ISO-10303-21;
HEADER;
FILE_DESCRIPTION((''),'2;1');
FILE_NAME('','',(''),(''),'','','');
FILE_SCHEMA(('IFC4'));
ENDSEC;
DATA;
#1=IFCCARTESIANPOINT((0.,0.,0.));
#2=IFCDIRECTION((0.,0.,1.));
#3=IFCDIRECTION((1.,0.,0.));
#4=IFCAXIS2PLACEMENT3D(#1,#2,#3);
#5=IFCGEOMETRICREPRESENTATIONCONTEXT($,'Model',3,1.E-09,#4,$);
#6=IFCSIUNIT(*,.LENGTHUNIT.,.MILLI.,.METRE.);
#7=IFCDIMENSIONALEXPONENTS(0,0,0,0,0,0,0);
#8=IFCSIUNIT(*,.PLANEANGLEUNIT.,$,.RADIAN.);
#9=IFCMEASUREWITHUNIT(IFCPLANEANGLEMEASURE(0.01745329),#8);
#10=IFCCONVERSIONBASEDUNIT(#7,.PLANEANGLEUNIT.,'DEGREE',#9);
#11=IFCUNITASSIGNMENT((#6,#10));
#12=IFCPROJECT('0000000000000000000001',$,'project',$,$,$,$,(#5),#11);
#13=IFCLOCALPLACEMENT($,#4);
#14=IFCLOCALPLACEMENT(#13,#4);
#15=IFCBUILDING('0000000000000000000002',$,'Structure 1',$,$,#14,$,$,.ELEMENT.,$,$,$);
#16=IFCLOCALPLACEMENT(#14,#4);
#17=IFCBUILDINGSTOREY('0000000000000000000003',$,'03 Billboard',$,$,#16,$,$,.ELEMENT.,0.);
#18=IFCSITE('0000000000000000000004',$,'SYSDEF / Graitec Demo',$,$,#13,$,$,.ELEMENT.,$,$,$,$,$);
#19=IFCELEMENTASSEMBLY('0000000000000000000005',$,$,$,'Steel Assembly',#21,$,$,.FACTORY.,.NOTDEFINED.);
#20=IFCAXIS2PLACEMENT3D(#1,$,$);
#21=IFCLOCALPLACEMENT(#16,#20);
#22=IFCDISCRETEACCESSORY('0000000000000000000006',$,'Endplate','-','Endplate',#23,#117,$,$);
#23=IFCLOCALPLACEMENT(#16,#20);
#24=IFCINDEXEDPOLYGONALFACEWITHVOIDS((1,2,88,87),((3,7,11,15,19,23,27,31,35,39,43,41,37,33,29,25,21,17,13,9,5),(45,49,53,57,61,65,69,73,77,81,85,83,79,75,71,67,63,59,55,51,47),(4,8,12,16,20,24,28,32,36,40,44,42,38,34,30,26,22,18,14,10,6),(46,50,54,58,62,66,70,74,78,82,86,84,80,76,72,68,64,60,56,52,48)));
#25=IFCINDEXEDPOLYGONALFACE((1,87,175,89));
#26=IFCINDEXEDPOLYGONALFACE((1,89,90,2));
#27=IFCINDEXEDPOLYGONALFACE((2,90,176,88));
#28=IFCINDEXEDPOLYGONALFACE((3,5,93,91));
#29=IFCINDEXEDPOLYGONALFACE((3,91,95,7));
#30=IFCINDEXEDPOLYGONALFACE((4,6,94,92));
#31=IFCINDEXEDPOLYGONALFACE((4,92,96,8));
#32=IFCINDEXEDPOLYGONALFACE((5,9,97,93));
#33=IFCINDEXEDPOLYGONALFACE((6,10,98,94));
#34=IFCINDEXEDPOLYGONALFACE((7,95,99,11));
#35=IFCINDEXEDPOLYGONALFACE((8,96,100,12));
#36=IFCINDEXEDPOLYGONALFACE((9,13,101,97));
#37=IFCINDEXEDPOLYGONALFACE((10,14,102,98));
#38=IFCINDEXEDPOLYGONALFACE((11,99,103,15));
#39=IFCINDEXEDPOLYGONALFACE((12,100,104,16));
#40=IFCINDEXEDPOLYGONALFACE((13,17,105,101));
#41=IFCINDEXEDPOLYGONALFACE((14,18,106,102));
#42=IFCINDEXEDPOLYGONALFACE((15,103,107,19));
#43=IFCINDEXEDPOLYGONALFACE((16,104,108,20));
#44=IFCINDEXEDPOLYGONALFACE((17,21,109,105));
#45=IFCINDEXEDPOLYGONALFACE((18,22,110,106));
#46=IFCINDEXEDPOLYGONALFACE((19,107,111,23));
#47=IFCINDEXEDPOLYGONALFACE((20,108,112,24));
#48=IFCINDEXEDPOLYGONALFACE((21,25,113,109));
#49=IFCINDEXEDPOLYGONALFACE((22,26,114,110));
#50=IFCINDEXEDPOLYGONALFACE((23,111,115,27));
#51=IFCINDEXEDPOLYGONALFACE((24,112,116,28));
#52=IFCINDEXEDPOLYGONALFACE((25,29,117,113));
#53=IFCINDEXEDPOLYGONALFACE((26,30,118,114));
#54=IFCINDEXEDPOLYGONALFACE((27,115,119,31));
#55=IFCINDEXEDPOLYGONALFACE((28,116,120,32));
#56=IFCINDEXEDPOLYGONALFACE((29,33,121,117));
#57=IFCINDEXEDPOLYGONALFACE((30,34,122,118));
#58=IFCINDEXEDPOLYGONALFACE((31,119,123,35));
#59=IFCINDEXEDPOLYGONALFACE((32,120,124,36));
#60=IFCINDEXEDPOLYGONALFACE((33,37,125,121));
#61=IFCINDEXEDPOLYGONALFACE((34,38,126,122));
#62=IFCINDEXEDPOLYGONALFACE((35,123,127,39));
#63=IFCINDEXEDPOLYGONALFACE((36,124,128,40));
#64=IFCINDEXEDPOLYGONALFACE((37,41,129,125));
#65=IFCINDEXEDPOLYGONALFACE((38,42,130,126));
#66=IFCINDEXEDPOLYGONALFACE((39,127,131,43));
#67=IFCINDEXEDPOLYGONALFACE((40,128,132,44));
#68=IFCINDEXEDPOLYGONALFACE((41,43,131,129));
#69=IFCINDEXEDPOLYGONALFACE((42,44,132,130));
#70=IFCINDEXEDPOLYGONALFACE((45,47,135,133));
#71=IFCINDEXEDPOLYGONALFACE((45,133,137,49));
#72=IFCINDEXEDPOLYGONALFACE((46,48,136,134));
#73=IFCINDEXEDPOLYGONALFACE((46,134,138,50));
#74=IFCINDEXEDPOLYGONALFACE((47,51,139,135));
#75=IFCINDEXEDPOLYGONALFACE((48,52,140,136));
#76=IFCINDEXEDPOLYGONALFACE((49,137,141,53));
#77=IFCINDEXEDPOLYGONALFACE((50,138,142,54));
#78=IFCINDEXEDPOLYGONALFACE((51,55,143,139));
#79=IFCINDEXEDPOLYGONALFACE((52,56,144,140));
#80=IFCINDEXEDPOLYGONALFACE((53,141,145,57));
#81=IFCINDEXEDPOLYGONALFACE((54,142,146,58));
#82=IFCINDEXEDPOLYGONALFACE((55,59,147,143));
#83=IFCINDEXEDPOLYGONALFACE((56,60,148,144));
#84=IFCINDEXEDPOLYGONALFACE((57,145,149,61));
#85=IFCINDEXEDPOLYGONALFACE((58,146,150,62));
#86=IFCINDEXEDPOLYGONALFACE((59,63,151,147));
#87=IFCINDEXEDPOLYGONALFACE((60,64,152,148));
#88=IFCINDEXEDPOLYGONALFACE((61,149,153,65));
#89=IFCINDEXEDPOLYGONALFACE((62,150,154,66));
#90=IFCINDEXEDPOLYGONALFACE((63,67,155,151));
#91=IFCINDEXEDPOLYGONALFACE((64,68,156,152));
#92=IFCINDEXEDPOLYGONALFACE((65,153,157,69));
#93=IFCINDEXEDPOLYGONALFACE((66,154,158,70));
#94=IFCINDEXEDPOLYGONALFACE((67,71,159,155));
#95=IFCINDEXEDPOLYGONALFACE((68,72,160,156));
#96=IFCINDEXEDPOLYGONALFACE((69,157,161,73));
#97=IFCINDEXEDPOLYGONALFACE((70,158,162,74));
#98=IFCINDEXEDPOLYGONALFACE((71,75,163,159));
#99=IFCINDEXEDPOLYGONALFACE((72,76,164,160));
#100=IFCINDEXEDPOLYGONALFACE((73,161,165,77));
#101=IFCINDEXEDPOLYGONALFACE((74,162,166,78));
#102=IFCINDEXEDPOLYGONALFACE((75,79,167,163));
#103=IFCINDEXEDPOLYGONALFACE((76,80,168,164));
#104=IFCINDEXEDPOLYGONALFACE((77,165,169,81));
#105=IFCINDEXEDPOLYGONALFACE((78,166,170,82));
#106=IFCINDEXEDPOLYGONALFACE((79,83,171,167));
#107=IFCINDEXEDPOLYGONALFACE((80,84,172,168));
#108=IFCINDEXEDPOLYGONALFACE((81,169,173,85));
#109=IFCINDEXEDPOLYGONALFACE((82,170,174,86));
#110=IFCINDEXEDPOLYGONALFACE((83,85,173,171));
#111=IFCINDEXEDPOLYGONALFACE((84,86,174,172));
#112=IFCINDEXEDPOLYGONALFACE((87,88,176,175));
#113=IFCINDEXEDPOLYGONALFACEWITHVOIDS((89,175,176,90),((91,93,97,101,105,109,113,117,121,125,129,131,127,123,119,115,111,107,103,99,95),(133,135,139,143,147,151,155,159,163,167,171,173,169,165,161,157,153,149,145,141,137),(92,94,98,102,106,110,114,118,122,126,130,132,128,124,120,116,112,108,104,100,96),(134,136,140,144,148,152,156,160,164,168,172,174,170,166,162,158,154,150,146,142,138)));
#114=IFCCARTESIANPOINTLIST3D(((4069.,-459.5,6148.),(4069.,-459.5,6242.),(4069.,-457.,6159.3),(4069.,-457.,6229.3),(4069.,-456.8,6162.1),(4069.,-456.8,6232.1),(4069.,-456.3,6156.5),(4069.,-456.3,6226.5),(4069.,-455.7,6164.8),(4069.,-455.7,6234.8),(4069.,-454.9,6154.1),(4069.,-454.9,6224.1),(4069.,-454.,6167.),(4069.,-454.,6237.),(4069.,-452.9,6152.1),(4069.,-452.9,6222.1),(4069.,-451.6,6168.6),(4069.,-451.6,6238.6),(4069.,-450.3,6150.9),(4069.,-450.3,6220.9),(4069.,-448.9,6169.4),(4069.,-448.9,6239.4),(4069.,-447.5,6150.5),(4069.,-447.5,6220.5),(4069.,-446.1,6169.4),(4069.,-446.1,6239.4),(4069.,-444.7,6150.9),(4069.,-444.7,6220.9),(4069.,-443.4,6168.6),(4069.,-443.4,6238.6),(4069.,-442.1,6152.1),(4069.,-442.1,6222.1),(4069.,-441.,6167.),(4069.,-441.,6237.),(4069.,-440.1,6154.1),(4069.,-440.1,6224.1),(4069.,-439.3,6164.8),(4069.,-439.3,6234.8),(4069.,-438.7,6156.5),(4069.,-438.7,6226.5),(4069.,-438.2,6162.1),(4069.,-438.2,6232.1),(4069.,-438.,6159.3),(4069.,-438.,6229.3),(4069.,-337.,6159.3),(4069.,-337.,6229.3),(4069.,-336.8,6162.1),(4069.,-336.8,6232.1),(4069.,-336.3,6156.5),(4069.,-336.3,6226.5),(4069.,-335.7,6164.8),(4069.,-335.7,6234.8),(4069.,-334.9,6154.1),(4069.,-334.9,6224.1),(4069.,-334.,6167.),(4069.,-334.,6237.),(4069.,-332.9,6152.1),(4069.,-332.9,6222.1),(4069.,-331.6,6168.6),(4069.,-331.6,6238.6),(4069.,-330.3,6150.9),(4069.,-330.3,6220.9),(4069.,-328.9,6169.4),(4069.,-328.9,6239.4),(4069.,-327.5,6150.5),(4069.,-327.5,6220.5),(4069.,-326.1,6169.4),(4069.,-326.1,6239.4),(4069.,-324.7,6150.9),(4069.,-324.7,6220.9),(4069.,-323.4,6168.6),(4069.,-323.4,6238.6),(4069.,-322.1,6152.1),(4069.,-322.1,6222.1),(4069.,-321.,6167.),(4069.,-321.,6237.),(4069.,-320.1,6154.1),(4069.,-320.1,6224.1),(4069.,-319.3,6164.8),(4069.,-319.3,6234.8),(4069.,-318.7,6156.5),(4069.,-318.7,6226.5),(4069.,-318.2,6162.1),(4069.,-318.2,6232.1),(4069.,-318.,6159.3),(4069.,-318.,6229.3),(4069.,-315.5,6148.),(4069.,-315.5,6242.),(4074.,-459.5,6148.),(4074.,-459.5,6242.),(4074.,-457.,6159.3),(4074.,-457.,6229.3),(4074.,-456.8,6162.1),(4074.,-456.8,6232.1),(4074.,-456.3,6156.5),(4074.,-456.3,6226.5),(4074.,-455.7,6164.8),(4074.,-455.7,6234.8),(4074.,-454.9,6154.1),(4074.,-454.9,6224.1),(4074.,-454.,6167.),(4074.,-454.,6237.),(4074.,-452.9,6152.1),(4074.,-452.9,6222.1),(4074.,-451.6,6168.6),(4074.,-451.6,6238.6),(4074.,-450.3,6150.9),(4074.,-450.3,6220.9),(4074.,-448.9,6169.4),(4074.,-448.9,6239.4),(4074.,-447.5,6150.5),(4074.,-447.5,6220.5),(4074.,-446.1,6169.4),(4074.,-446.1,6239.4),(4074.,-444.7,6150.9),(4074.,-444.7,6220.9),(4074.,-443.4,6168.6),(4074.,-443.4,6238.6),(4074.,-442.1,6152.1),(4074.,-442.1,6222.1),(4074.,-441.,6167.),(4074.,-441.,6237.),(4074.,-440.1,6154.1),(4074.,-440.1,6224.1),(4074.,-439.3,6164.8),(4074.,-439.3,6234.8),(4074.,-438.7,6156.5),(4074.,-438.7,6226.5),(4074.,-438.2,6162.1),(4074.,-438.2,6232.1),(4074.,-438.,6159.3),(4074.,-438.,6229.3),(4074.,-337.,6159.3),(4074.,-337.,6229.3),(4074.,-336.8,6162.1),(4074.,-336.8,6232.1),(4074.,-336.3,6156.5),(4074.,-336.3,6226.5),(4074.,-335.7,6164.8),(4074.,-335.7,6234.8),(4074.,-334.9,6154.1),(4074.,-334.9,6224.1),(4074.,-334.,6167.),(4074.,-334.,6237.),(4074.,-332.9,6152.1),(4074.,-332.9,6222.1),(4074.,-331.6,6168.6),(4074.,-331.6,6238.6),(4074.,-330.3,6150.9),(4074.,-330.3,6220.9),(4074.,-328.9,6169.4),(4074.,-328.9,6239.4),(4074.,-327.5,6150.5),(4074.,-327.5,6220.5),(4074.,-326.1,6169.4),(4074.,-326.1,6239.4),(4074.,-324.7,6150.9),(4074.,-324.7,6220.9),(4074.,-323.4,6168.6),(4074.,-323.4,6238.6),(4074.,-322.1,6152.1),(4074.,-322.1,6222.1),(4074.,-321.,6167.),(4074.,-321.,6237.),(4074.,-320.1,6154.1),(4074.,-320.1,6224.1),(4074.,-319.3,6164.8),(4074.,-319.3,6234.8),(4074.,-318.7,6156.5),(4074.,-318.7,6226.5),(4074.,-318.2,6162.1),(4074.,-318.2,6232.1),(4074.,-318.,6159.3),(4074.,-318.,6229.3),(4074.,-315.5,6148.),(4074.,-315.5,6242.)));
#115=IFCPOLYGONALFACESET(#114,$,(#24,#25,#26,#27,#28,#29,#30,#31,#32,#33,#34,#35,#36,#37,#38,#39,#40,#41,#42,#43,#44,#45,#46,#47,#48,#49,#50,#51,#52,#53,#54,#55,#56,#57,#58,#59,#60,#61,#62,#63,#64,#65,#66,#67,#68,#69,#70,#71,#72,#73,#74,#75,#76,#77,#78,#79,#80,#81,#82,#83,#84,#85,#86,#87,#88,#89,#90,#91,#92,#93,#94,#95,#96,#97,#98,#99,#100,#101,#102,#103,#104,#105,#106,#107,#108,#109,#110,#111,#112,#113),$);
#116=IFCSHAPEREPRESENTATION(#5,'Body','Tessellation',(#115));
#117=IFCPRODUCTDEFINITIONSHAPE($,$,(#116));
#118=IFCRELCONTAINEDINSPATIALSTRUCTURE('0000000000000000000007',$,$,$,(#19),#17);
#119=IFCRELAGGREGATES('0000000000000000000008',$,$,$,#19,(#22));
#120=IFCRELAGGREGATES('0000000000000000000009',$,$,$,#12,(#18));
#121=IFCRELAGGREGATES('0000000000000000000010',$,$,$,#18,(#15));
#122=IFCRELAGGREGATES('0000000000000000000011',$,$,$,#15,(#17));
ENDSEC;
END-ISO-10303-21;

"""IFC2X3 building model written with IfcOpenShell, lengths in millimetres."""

from ifc_helpers import new_model, entity, si_unit, converted_unit, frame, frame_2d, origin, origin_with_axes, place, context, project, spatial, polyline, circle, outline, extrude, element, aggregate, save


model = new_model("IFC2X3")

# Units and contexts
model_context = context("Model", 3, precision=1e-09, world=origin_with_axes())
ifc_project = project(units=[si_unit("LENGTHUNIT", "METRE", prefix="MILLI"), converted_unit("PLANEANGLEUNIT", "DEGREE", entity("IfcPlaneAngleMeasure", 0.01745329), si_unit("PLANEANGLEUNIT", "RADIAN"), dimensions=[0, 0, 0, 0, 0, 0, 0])], contexts=[model_context])

# Site, building, storey
site_placement = place(None, origin_with_axes())
site = spatial("IfcSite", under=ifc_project, at=site_placement, Name="SYSDEF / Graitec Demo", CompositionType="ELEMENT")
building_placement = place(site_placement, origin_with_axes())
building = spatial("IfcBuilding", under=site, at=building_placement, Name="Structure 1", CompositionType="ELEMENT")
storey_placement = place(building_placement, origin_with_axes())
storey = spatial("IfcBuildingStorey", under=building, at=storey_placement, Name="03 Billboard", CompositionType="ELEMENT", Elevation=0.0)

# Element assembly, discrete accessory, openings
assembly_1_placement = place(None, frame((-4239.1, -387.5, 4000.0), z_axis=(-1.0, 0.0, 0.0), x_axis=(0.0, 0.0, 1.0)))
assembly_1 = element("IfcElementAssembly", 1, at=assembly_1_placement, inside=storey, ObjectType="Steel Assembly", AssemblyPlace="FACTORY", PredefinedType="NOTDEFINED")
discrete_accessory_1_placement = place(assembly_1_placement, frame((2148.0, 72.0, -8308.1), z_axis=(0.0, 0.0, -1.0), x_axis=(1.0, 0.0, 0.0)))
discrete_accessory_1 = element("IfcDiscreteAccessory", 2, at=discrete_accessory_1_placement, Name="Endplate", Description="-", ObjectType="Endplate", context=model_context, shape_type="SweptSolid", body=[
    extrude(outline(polyline([(0.0, 0.0), (94.0, 0.0), (94.0, 144.0), (0.0, 144.0), (0.0, 0.0)])), origin_with_axes(), (0.0, 0.0, 1.0), 5.0),
])
opening_1_placement = place(discrete_accessory_1_placement, frame((47.0, 72.0, -0.5), z_axis=(0.0, 0.0, 1.0), x_axis=(-1.0, 0.0, 0.0)))
element("IfcOpeningElement", 3, at=opening_1_placement, cuts=discrete_accessory_1, ObjectType="Opening", context=model_context, shape_type="SweptSolid", body=[
    extrude(circle(Radius=9.5, at=frame_2d((35.0, 60.0), x_axis=(1.0, 0.0))), origin(), (0.0, 0.0, 1.0), 6.0),
])
opening_2_placement = place(discrete_accessory_1_placement, frame((47.0, 72.0, -0.5), z_axis=(0.0, 0.0, 1.0), x_axis=(-1.0, 0.0, 0.0)))
element("IfcOpeningElement", 4, at=opening_2_placement, cuts=discrete_accessory_1, ObjectType="Opening", context=model_context, shape_type="SweptSolid", body=[
    extrude(circle(Radius=9.5, at=frame_2d((-35.0, 60.0), x_axis=(1.0, 0.0))), origin(), (0.0, 0.0, 1.0), 6.0),
])
opening_3_placement = place(discrete_accessory_1_placement, frame((47.0, 72.0, -0.5), z_axis=(0.0, 0.0, 1.0), x_axis=(-1.0, 0.0, 0.0)))
element("IfcOpeningElement", 5, at=opening_3_placement, cuts=discrete_accessory_1, ObjectType="Opening", context=model_context, shape_type="SweptSolid", body=[
    extrude(circle(Radius=9.5, at=frame_2d((35.0, -60.0), x_axis=(1.0, 0.0))), origin(), (0.0, 0.0, 1.0), 6.0),
])
opening_4_placement = place(discrete_accessory_1_placement, frame((47.0, 72.0, -0.5), z_axis=(0.0, 0.0, 1.0), x_axis=(-1.0, 0.0, 0.0)))
element("IfcOpeningElement", 6, at=opening_4_placement, cuts=discrete_accessory_1, ObjectType="Opening", context=model_context, shape_type="SweptSolid", body=[
    extrude(circle(Radius=9.5, at=frame_2d((-35.0, -60.0), x_axis=(1.0, 0.0))), origin(), (0.0, 0.0, 1.0), 6.0),
])
aggregate(assembly_1, [discrete_accessory_1])

save(model, "model.ifc")
